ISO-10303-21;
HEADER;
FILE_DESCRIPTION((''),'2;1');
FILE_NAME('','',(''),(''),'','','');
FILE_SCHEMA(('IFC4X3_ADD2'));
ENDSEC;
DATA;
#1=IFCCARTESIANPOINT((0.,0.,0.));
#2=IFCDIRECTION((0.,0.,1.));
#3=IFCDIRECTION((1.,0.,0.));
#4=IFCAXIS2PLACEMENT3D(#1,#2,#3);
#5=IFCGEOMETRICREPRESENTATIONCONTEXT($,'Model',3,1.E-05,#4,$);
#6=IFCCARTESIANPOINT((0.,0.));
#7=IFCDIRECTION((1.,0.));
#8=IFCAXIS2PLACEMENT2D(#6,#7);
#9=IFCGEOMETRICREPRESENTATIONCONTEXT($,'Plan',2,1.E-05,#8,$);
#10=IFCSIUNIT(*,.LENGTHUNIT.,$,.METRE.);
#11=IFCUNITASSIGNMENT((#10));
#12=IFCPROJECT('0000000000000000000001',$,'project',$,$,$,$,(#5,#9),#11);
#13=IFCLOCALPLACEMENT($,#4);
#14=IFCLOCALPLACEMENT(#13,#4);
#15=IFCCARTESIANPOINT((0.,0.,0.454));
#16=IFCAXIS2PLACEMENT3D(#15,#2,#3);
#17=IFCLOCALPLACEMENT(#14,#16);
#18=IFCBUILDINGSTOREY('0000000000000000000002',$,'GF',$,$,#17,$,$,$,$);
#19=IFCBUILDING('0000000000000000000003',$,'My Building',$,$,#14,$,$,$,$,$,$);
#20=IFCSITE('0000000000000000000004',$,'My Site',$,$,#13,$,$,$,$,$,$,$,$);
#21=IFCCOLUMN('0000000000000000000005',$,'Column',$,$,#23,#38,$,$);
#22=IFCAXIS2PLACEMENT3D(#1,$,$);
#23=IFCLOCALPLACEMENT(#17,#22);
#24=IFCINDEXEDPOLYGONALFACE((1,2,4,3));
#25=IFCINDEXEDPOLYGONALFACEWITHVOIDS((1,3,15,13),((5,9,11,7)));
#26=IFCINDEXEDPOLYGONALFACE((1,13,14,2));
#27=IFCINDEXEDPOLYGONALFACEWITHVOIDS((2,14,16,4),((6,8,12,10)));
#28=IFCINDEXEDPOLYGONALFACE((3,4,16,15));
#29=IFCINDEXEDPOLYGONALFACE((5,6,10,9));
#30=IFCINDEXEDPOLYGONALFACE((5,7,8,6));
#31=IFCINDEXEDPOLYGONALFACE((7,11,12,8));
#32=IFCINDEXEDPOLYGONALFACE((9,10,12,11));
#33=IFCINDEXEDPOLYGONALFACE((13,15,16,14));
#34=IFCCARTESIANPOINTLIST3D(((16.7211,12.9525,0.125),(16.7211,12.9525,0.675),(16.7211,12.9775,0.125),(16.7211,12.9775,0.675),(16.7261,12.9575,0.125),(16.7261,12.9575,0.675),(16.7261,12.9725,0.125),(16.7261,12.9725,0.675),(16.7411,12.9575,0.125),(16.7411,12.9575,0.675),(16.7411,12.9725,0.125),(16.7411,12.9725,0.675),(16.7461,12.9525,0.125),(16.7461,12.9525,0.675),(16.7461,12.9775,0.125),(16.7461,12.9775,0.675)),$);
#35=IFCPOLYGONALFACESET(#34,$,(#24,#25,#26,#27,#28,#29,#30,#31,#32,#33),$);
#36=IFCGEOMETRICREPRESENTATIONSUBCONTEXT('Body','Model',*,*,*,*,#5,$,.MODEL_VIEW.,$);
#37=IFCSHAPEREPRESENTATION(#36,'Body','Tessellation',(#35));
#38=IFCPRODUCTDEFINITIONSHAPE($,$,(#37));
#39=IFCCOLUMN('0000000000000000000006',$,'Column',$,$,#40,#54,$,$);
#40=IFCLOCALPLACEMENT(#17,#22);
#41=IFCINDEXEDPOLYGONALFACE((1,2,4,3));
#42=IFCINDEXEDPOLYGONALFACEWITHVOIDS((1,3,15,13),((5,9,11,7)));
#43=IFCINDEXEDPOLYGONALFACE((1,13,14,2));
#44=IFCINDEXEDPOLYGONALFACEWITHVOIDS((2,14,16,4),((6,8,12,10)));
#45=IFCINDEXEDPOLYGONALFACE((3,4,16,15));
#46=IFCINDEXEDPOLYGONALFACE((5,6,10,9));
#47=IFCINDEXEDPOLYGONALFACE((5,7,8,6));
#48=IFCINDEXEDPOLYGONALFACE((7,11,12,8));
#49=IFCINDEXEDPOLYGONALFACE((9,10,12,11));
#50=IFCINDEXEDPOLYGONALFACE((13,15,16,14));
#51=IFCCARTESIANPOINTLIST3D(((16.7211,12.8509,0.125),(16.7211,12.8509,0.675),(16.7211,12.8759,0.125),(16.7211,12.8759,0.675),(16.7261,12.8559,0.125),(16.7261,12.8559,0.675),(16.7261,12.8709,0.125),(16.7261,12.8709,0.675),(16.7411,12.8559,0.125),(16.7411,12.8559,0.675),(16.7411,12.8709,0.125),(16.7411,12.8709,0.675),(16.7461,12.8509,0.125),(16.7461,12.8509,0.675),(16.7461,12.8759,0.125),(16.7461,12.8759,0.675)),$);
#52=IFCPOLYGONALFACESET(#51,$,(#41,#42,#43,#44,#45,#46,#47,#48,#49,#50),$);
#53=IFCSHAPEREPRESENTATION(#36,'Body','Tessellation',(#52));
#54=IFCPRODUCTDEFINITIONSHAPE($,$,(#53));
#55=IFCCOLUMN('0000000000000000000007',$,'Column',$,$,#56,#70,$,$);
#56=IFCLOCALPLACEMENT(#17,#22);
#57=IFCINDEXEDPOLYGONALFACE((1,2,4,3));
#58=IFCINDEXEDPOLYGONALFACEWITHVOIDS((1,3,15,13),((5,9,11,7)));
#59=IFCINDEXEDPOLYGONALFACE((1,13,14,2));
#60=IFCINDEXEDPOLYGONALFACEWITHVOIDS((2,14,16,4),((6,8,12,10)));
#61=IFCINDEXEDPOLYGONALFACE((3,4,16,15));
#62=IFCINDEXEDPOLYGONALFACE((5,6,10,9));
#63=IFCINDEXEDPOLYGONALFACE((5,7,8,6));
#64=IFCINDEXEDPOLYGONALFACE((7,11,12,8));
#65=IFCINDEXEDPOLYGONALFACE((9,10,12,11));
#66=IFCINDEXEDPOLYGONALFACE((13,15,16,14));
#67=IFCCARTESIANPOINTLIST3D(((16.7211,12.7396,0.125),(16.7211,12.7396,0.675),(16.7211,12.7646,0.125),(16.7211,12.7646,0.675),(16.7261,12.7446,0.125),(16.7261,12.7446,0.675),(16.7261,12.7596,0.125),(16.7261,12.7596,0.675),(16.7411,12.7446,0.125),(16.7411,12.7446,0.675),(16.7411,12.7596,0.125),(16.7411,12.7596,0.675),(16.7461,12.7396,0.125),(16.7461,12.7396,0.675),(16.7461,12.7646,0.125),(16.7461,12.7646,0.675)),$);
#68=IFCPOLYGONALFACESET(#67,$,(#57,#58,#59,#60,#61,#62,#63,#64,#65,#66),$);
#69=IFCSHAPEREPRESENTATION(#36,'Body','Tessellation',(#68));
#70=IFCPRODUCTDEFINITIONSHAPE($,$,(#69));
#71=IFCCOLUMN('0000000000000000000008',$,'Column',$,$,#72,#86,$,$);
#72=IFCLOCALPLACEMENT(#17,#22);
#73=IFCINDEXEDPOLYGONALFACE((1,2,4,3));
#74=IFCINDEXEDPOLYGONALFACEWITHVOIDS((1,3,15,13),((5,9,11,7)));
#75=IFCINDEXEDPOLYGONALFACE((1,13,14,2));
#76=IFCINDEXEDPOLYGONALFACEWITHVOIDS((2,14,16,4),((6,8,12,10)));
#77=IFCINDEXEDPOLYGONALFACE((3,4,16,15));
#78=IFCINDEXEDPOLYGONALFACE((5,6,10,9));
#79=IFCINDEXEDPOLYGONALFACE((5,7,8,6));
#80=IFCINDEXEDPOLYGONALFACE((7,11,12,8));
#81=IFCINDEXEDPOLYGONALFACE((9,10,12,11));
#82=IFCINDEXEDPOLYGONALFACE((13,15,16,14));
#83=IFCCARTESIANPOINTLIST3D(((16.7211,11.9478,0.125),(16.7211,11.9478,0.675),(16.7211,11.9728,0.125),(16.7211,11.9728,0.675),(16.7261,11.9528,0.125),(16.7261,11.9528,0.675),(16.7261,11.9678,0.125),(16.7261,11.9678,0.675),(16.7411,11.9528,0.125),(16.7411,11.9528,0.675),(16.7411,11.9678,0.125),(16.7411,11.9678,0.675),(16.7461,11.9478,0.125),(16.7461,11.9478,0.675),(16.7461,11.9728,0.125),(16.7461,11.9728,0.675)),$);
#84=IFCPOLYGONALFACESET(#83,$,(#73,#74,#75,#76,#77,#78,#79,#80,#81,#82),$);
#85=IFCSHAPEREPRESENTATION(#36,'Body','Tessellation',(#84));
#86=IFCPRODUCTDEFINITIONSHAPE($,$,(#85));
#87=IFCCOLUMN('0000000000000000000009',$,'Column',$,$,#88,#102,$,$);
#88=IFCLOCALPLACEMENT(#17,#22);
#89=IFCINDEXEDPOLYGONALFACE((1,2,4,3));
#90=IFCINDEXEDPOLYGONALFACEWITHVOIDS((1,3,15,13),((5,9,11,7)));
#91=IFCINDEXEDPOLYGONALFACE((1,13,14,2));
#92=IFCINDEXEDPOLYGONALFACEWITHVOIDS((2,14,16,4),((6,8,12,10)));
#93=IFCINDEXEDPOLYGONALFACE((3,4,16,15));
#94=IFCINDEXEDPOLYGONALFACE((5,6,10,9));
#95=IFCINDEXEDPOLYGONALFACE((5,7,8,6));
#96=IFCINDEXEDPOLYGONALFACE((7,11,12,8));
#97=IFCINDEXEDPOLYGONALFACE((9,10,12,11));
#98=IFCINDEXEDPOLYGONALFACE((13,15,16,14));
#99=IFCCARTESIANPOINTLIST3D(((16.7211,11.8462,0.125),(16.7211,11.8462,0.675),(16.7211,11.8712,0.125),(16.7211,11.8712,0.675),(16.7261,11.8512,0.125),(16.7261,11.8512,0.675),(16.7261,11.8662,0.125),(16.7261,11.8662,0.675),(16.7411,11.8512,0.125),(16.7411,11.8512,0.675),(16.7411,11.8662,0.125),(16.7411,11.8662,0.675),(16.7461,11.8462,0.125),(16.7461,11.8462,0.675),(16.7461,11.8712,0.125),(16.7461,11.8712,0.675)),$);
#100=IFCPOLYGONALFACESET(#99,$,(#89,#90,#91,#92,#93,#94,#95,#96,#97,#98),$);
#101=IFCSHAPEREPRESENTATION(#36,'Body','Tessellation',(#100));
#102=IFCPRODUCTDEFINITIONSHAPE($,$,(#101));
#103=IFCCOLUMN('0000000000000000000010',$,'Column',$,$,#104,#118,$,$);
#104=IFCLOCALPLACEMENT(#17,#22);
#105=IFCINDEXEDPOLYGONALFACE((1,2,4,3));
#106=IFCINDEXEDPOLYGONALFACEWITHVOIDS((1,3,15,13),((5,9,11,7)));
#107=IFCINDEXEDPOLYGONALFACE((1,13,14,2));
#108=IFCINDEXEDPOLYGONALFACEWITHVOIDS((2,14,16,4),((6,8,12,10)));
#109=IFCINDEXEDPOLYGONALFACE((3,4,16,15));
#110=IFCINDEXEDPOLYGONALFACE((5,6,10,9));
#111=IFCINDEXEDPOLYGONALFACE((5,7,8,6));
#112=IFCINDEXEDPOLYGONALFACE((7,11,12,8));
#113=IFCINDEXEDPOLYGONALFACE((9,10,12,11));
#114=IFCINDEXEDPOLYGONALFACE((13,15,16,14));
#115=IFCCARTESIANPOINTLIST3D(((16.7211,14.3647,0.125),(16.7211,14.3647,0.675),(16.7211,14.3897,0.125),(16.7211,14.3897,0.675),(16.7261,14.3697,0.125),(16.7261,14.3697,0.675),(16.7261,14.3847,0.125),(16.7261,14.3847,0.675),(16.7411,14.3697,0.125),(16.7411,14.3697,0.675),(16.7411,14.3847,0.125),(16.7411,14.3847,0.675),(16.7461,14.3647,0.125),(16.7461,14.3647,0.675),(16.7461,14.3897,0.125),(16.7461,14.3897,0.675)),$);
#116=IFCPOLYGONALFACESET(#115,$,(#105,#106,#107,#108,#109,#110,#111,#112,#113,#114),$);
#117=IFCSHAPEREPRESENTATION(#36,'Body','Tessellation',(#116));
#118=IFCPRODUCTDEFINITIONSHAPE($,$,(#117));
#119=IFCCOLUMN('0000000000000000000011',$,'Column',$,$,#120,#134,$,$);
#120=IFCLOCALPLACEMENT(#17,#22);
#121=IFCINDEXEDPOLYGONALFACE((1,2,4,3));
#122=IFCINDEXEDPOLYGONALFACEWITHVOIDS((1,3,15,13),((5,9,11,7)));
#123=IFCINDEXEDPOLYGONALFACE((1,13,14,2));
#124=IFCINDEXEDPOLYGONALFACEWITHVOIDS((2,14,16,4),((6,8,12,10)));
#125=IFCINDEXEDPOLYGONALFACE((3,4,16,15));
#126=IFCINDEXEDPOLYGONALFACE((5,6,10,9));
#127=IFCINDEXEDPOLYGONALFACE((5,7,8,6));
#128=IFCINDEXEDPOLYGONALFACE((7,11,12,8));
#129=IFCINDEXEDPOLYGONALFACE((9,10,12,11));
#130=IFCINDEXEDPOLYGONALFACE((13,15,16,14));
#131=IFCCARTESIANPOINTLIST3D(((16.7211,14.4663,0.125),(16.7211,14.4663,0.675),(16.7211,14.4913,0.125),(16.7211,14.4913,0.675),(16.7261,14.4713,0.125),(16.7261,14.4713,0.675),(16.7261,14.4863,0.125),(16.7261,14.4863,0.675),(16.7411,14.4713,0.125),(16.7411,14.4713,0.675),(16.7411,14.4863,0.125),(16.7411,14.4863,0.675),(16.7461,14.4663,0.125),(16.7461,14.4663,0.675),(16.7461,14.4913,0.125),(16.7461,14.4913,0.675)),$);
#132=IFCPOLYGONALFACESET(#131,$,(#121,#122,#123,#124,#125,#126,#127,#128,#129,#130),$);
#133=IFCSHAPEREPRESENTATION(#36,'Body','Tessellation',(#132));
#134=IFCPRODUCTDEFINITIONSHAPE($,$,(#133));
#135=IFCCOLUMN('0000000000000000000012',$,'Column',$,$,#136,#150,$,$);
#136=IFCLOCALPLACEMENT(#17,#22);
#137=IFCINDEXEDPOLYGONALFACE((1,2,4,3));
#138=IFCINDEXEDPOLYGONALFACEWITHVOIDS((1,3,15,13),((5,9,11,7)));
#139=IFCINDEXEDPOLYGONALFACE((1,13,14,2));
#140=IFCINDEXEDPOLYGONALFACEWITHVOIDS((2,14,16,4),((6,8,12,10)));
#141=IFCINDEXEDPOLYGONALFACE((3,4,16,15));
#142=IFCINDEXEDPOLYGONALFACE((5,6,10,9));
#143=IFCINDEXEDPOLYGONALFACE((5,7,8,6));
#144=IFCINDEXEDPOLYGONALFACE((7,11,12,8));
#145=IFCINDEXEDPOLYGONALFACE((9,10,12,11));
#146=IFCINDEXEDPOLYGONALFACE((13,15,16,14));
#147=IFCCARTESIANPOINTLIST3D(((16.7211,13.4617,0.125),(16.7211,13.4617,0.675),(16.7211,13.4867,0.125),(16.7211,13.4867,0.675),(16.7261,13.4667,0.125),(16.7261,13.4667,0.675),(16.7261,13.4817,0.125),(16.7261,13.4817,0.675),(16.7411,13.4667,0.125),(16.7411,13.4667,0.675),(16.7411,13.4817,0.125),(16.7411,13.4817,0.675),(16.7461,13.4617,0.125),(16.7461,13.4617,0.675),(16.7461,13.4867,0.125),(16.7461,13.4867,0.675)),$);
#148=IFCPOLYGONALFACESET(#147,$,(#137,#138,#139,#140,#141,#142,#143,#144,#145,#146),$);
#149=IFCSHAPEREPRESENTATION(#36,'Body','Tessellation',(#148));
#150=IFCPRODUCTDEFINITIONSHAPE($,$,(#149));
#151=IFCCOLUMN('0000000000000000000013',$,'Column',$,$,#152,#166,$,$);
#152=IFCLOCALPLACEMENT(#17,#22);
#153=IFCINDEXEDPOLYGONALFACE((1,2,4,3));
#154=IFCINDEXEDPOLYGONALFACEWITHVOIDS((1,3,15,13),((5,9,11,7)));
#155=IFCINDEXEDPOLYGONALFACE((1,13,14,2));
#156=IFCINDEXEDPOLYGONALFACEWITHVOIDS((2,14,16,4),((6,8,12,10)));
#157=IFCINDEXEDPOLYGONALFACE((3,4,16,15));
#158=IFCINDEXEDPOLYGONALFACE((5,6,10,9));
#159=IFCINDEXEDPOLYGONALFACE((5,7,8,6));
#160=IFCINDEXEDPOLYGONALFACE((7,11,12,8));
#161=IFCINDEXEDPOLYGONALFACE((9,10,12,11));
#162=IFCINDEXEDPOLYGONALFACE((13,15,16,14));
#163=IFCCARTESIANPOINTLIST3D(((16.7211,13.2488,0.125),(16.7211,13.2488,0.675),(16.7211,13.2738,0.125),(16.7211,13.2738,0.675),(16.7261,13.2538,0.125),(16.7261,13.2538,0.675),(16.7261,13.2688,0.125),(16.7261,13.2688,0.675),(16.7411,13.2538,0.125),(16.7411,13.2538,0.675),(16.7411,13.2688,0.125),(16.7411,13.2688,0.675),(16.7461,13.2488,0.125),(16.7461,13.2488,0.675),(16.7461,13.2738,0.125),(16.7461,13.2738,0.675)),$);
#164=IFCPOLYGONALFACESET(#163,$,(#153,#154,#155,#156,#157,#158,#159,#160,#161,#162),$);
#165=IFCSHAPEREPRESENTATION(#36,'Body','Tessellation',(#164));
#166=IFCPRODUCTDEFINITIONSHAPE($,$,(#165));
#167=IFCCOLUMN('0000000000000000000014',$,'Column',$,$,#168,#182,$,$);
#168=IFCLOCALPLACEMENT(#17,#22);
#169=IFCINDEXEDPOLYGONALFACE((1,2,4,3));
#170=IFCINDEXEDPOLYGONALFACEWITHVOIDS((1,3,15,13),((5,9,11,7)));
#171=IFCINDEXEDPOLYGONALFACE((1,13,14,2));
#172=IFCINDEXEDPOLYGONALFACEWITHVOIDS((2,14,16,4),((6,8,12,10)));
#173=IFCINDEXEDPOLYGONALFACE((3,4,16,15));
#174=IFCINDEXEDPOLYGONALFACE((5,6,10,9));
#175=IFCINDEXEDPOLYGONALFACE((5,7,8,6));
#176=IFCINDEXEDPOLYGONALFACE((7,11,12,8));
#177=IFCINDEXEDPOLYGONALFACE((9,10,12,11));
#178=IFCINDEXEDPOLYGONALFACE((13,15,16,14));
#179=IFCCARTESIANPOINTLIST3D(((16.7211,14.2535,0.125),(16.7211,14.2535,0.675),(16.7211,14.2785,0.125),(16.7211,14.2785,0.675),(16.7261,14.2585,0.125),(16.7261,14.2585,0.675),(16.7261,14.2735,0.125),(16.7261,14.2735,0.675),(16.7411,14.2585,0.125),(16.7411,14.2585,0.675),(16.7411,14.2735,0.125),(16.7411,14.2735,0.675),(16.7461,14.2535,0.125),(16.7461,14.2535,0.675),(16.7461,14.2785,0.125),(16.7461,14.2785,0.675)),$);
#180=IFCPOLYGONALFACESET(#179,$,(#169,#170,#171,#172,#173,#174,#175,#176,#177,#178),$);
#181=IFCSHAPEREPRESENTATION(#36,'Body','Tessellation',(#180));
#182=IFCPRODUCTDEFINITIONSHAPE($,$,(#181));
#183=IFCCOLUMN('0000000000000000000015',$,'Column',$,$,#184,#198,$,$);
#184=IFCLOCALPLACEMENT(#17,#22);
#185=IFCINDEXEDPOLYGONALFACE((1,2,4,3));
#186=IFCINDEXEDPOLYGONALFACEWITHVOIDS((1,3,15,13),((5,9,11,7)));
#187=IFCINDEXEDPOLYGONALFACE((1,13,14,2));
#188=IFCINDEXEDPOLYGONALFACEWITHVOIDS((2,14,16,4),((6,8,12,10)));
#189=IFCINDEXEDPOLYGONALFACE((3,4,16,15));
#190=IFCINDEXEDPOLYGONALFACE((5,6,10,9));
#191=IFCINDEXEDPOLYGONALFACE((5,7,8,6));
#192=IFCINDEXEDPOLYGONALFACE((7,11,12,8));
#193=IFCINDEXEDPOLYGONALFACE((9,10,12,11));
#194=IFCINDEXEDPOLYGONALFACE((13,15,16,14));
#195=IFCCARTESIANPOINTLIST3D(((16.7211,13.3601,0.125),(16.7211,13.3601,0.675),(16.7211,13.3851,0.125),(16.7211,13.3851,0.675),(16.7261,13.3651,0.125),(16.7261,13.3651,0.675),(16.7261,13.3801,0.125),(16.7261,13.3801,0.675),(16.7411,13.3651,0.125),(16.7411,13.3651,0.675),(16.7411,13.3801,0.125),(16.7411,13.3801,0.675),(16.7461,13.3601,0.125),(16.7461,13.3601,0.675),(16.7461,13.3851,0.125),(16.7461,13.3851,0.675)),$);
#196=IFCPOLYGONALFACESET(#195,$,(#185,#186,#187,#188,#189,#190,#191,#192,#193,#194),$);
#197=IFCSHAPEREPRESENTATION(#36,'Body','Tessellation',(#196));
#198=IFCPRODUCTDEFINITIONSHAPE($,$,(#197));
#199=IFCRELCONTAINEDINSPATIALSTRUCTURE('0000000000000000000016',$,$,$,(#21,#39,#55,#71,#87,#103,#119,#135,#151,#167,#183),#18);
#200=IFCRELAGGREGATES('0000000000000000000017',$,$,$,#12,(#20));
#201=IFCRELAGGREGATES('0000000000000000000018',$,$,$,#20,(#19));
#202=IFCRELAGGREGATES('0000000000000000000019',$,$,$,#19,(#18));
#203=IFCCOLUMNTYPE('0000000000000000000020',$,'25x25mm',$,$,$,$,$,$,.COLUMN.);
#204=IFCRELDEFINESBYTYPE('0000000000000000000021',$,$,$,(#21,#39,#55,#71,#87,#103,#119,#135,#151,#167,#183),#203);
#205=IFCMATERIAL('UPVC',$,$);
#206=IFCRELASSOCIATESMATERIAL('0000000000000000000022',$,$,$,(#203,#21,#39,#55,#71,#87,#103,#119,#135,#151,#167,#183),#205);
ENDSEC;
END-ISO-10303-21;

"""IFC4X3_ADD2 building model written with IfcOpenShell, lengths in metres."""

from ifc_helpers import new_model, si_unit, frame, origin_with_axes, origin_2d_with_axis, place, context, subcontext, project, spatial, hollow_rectangle, extrude, material, material_profile, profile_set, profile_usage, type_object, element, save


model = new_model("IFC4X3_ADD2")

# Units and contexts
model_context = context("Model", 3, precision=1e-05, world=origin_with_axes())
plan_context = context("Plan", 2, precision=1e-05, world=origin_2d_with_axis())
body_context = subcontext(model_context, "Body", "Model", "MODEL_VIEW")
ifc_project = project(units=[si_unit("LENGTHUNIT", "METRE")], contexts=[model_context, plan_context])

# Site, building, storey
site_placement = place(None, origin_with_axes())
site = spatial("IfcSite", under=ifc_project, at=site_placement, Name="My Site")
building_placement = place(site_placement, origin_with_axes())
building = spatial("IfcBuilding", under=site, at=building_placement, Name="My Building")
storey_placement = place(building_placement, frame((0.0, 0.0, 0.454), z_axis=(0.0, 0.0, 1.0), x_axis=(1.0, 0.0, 0.0)))
storey = spatial("IfcBuildingStorey", under=building, at=storey_placement, Name="GF")

# Columns
ifc_material = material(Name="UPVC")
ifc_material_profile_1 = material_profile(ifc_material, hollow_rectangle(XDim=0.025, YDim=0.025, WallThickness=0.005))
ifc_profile_set_1 = profile_set([ifc_material_profile_1])
ifc_profile_usage_1 = profile_usage(ifc_profile_set_1)
column_type_1 = type_object("IfcColumnType", Name="25x25mm", PredefinedType="COLUMN", material=ifc_profile_set_1)
column_1_placement = place(storey_placement, frame((16.7336, 12.965, 0.125), z_axis=(0.0, 0.0, 1.0), x_axis=(0.0, -1.0, 0.0)))
element("IfcColumn", 1, at=column_1_placement, inside=storey, type_object=column_type_1, material=ifc_profile_usage_1, Name="Column", context=body_context, shape_type="SweptSolid", body=[
    extrude(hollow_rectangle(XDim=0.025, YDim=0.025, WallThickness=0.005), origin_with_axes(), (0.0, 0.0, 1.0), 0.55),
])
ifc_profile_usage_2 = profile_usage(ifc_profile_set_1)
column_2_placement = place(storey_placement, frame((16.7336, 12.8634, 0.125), z_axis=(0.0, 0.0, 1.0), x_axis=(0.0, -1.0, 0.0)))
element("IfcColumn", 2, at=column_2_placement, inside=storey, type_object=column_type_1, material=ifc_profile_usage_2, Name="Column", context=body_context, shape_type="SweptSolid", body=[
    extrude(hollow_rectangle(XDim=0.025, YDim=0.025, WallThickness=0.005), origin_with_axes(), (0.0, 0.0, 1.0), 0.55),
])
ifc_profile_usage_3 = profile_usage(ifc_profile_set_1)
column_3_placement = place(storey_placement, frame((16.7336, 12.7521, 0.125), z_axis=(0.0, 0.0, 1.0), x_axis=(0.0, -1.0, 0.0)))
element("IfcColumn", 3, at=column_3_placement, inside=storey, type_object=column_type_1, material=ifc_profile_usage_3, Name="Column", context=body_context, shape_type="SweptSolid", body=[
    extrude(hollow_rectangle(XDim=0.025, YDim=0.025, WallThickness=0.005), origin_with_axes(), (0.0, 0.0, 1.0), 0.55),
])
ifc_profile_usage_4 = profile_usage(ifc_profile_set_1)
column_4_placement = place(storey_placement, frame((16.7336, 11.9603, 0.125), z_axis=(0.0, 0.0, 1.0), x_axis=(0.0, -1.0, 0.0)))
element("IfcColumn", 4, at=column_4_placement, inside=storey, type_object=column_type_1, material=ifc_profile_usage_4, Name="Column", context=body_context, shape_type="SweptSolid", body=[
    extrude(hollow_rectangle(XDim=0.025, YDim=0.025, WallThickness=0.005), origin_with_axes(), (0.0, 0.0, 1.0), 0.55),
])
ifc_profile_usage_5 = profile_usage(ifc_profile_set_1)
column_5_placement = place(storey_placement, frame((16.7336, 11.8587, 0.125), z_axis=(0.0, 0.0, 1.0), x_axis=(0.0, -1.0, 0.0)))
element("IfcColumn", 5, at=column_5_placement, inside=storey, type_object=column_type_1, material=ifc_profile_usage_5, Name="Column", context=body_context, shape_type="SweptSolid", body=[
    extrude(hollow_rectangle(XDim=0.025, YDim=0.025, WallThickness=0.005), origin_with_axes(), (0.0, 0.0, 1.0), 0.55),
])
ifc_profile_usage_6 = profile_usage(ifc_profile_set_1)
column_6_placement = place(storey_placement, frame((16.7336, 14.3772, 0.125), z_axis=(0.0, 0.0, 1.0), x_axis=(0.0, -1.0, 0.0)))
element("IfcColumn", 6, at=column_6_placement, inside=storey, type_object=column_type_1, material=ifc_profile_usage_6, Name="Column", context=body_context, shape_type="SweptSolid", body=[
    extrude(hollow_rectangle(XDim=0.025, YDim=0.025, WallThickness=0.005), origin_with_axes(), (0.0, 0.0, 1.0), 0.55),
])
ifc_profile_usage_7 = profile_usage(ifc_profile_set_1)
column_7_placement = place(storey_placement, frame((16.7336, 14.4788, 0.125), z_axis=(0.0, 0.0, 1.0), x_axis=(0.0, -1.0, 0.0)))
element("IfcColumn", 7, at=column_7_placement, inside=storey, type_object=column_type_1, material=ifc_profile_usage_7, Name="Column", context=body_context, shape_type="SweptSolid", body=[
    extrude(hollow_rectangle(XDim=0.025, YDim=0.025, WallThickness=0.005), origin_with_axes(), (0.0, 0.0, 1.0), 0.55),
])
ifc_profile_usage_8 = profile_usage(ifc_profile_set_1)
column_8_placement = place(storey_placement, frame((16.7336, 13.4742, 0.125), z_axis=(0.0, 0.0, 1.0), x_axis=(0.0, -1.0, 0.0)))
element("IfcColumn", 8, at=column_8_placement, inside=storey, type_object=column_type_1, material=ifc_profile_usage_8, Name="Column", context=body_context, shape_type="SweptSolid", body=[
    extrude(hollow_rectangle(XDim=0.025, YDim=0.025, WallThickness=0.005), origin_with_axes(), (0.0, 0.0, 1.0), 0.55),
])
ifc_profile_usage_9 = profile_usage(ifc_profile_set_1)
column_9_placement = place(storey_placement, frame((16.7336, 13.2613, 0.125), z_axis=(0.0, 0.0, 1.0), x_axis=(0.0, -1.0, 0.0)))
element("IfcColumn", 9, at=column_9_placement, inside=storey, type_object=column_type_1, material=ifc_profile_usage_9, Name="Column", context=body_context, shape_type="SweptSolid", body=[
    extrude(hollow_rectangle(XDim=0.025, YDim=0.025, WallThickness=0.005), origin_with_axes(), (0.0, 0.0, 1.0), 0.55),
])
ifc_profile_usage_10 = profile_usage(ifc_profile_set_1)
column_10_placement = place(storey_placement, frame((16.7336, 14.266, 0.125), z_axis=(0.0, 0.0, 1.0), x_axis=(0.0, -1.0, 0.0)))
element("IfcColumn", 10, at=column_10_placement, inside=storey, type_object=column_type_1, material=ifc_profile_usage_10, Name="Column", context=body_context, shape_type="SweptSolid", body=[
    extrude(hollow_rectangle(XDim=0.025, YDim=0.025, WallThickness=0.005), origin_with_axes(), (0.0, 0.0, 1.0), 0.55),
])
ifc_profile_usage_11 = profile_usage(ifc_profile_set_1)
column_11_placement = place(storey_placement, frame((16.7336, 13.3726, 0.125), z_axis=(0.0, 0.0, 1.0), x_axis=(0.0, -1.0, 0.0)))
element("IfcColumn", 11, at=column_11_placement, inside=storey, type_object=column_type_1, material=ifc_profile_usage_11, Name="Column", context=body_context, shape_type="SweptSolid", body=[
    extrude(hollow_rectangle(XDim=0.025, YDim=0.025, WallThickness=0.005), origin_with_axes(), (0.0, 0.0, 1.0), 0.55),
])

save(model, "model.ifc")
